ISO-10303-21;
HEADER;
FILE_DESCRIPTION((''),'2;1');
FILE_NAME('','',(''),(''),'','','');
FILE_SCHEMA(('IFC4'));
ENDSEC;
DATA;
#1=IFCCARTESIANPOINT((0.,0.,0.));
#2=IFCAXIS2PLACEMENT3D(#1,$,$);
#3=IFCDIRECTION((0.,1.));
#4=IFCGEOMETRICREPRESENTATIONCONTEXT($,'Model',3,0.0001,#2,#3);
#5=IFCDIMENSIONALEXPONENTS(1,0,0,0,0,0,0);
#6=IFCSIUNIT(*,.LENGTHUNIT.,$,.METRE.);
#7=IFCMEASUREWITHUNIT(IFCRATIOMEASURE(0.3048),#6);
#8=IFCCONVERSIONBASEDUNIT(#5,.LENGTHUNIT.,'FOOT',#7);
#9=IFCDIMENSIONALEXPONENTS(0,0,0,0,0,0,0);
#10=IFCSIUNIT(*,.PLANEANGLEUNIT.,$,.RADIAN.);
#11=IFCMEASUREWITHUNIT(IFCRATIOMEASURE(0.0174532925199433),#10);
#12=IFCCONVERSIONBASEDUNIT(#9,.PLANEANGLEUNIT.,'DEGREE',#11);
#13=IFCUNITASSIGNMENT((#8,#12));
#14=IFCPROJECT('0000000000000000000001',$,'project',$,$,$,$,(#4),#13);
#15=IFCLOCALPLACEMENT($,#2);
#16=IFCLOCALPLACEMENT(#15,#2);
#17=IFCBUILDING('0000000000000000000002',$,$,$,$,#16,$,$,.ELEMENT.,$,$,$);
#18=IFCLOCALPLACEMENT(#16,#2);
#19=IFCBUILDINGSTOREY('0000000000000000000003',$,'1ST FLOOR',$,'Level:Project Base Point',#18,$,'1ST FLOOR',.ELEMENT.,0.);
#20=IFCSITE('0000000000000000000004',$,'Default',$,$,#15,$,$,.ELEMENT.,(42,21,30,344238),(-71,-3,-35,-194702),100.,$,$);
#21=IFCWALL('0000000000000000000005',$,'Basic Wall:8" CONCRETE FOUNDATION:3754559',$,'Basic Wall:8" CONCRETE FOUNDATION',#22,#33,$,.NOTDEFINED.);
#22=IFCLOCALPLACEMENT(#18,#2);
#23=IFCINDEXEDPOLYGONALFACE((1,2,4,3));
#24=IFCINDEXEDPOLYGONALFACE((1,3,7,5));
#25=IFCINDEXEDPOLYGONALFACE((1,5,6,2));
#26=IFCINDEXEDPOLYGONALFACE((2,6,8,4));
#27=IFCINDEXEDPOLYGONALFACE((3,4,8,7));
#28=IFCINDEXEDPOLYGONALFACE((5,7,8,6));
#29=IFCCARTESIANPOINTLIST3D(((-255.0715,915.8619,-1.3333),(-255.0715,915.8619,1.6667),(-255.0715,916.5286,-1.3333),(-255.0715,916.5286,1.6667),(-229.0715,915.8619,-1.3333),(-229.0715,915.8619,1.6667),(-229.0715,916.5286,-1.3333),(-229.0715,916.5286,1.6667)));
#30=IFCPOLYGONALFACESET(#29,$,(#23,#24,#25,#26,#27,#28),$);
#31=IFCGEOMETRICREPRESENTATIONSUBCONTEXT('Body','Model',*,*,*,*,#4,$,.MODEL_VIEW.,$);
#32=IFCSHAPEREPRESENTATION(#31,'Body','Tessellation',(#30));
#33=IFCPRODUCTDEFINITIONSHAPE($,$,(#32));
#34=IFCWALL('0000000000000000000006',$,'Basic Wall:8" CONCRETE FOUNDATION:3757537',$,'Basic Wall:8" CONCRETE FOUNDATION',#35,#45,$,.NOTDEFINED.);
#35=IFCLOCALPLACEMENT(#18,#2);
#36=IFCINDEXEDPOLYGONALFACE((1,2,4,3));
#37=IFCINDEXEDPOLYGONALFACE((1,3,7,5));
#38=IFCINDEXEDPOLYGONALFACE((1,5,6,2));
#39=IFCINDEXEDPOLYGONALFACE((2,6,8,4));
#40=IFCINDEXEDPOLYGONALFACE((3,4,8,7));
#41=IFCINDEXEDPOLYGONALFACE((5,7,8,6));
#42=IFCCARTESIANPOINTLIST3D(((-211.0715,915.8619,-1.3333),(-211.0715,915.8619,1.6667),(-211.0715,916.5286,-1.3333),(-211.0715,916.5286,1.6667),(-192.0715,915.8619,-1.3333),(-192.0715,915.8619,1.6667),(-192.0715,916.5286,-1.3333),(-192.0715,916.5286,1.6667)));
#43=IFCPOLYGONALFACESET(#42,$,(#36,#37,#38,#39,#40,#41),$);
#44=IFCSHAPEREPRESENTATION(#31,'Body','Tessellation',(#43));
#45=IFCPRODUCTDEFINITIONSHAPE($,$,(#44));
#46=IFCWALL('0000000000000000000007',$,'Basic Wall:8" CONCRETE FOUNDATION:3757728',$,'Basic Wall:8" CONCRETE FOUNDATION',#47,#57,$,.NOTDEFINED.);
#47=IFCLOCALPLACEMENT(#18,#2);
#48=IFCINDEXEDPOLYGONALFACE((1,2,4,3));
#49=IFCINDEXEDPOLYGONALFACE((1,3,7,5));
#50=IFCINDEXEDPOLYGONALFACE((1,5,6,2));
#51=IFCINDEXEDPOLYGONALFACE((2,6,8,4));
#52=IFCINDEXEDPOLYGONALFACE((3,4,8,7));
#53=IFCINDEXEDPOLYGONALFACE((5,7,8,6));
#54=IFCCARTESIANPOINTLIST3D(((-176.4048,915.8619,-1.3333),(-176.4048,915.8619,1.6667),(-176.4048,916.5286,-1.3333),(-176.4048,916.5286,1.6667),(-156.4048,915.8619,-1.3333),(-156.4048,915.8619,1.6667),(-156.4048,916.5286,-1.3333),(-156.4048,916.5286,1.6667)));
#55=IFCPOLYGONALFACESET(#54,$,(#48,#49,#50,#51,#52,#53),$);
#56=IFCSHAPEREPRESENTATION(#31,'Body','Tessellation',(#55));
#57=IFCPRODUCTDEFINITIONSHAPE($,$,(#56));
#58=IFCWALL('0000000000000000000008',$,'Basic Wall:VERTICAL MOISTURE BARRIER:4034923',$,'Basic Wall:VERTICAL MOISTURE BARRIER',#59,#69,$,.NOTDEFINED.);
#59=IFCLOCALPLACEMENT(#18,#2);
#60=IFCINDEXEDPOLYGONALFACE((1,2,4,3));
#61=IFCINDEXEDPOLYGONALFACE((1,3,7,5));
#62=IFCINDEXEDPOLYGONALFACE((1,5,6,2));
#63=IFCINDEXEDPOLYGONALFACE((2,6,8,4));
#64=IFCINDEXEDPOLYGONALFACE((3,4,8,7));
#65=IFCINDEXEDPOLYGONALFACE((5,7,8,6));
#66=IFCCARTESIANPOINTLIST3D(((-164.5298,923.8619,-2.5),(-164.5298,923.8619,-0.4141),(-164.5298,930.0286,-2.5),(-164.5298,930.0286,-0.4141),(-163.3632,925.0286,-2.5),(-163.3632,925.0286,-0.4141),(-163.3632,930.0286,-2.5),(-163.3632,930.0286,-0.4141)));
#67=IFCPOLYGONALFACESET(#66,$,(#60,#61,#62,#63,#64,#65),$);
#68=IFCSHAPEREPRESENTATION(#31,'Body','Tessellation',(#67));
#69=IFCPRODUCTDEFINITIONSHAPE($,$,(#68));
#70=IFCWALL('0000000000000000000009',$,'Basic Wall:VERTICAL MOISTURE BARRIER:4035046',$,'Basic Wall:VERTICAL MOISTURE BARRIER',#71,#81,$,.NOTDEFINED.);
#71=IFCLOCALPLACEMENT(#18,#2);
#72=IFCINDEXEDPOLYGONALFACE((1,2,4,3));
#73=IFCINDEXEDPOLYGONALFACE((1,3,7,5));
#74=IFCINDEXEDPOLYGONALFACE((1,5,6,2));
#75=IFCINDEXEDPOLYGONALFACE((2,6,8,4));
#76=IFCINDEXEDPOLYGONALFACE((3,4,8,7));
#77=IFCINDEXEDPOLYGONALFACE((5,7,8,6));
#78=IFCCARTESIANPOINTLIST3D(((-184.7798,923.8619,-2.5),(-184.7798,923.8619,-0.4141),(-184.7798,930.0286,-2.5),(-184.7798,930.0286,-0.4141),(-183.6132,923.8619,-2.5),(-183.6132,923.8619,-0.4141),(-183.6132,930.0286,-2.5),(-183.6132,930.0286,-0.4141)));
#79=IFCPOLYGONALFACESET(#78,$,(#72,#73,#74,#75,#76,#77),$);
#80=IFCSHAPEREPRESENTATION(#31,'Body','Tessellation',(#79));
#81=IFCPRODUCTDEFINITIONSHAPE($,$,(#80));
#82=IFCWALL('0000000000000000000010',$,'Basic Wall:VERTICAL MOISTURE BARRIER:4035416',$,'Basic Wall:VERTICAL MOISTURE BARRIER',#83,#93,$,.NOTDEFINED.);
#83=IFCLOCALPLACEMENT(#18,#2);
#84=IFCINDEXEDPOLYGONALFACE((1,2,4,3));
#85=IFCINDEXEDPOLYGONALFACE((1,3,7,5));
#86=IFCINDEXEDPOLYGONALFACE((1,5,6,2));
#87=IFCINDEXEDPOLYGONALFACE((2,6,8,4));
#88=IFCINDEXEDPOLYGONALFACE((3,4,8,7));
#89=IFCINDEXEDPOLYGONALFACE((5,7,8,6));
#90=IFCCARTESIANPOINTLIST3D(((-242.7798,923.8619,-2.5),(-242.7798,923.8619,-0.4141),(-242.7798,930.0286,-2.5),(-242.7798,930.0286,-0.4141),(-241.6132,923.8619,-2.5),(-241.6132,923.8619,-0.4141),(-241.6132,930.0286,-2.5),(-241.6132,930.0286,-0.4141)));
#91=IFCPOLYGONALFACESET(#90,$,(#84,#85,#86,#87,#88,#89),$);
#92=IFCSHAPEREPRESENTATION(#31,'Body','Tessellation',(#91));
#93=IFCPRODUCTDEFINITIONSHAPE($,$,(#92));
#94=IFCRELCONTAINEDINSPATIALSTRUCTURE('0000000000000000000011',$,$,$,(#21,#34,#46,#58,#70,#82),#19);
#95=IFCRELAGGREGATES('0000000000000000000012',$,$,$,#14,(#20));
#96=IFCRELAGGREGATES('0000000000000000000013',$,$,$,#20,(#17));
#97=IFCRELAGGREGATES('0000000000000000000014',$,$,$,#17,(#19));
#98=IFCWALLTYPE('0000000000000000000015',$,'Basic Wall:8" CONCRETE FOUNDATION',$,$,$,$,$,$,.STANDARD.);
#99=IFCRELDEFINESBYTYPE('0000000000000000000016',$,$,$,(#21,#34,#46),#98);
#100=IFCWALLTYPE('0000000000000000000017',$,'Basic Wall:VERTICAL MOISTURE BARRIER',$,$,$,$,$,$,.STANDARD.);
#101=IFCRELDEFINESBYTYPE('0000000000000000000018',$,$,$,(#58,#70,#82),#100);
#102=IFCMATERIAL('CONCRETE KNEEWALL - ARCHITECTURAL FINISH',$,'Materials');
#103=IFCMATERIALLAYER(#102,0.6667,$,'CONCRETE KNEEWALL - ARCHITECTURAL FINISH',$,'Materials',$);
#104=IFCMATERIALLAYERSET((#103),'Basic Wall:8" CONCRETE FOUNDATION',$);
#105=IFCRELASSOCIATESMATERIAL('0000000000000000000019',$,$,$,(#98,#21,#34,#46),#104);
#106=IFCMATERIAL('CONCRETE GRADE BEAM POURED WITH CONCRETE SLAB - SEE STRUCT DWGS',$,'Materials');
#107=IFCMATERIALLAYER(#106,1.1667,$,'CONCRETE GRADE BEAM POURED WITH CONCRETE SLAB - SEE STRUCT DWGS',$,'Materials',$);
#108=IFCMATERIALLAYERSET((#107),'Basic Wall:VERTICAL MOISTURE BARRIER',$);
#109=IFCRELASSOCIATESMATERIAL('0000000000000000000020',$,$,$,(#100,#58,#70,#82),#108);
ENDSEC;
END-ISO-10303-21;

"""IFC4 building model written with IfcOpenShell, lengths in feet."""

from ifc_helpers import new_model, entity, si_unit, converted_unit, direction, frame, frame_2d, origin, place, context, subcontext, project, spatial, polyline, rectangle, outline, extrude, clip, bounded_halfspace, material, layer, layer_set, layer_usage, type_object, element, save


model = new_model("IFC4")

# Units and contexts
model_context = context("Model", 3, precision=0.0001, world=origin(), true_north=direction((0.0, 1.0)))
body_context = subcontext(model_context, "Body", "Model", "MODEL_VIEW")
ifc_project = project(units=[converted_unit("LENGTHUNIT", "FOOT", entity("IfcRatioMeasure", 0.3048), si_unit("LENGTHUNIT", "METRE"), dimensions=[1, 0, 0, 0, 0, 0, 0]), converted_unit("PLANEANGLEUNIT", "DEGREE", entity("IfcRatioMeasure", 0.0174532925199433), si_unit("PLANEANGLEUNIT", "RADIAN"), dimensions=[0, 0, 0, 0, 0, 0, 0])], contexts=[model_context])

# Site, building, storey
site_placement = place(None, origin())
site = spatial("IfcSite", under=ifc_project, at=site_placement, Name="Default", CompositionType="ELEMENT", RefLatitude=(42, 21, 30, 344238), RefLongitude=(-71, -3, -35, -194702), RefElevation=100.0)
building_placement = place(site_placement, origin())
building = spatial("IfcBuilding", under=site, at=building_placement, CompositionType="ELEMENT")
storey_placement = place(building_placement, origin())
storey = spatial("IfcBuildingStorey", under=building, at=storey_placement, Name="1ST FLOOR", ObjectType="Level:Project Base Point", LongName="1ST FLOOR", CompositionType="ELEMENT", Elevation=0.0)

# Walls
ifc_material_1 = material(Name="CONCRETE KNEEWALL - ARCHITECTURAL FINISH", Category="Materials")
ifc_layer_1 = layer(ifc_material_1, 0.6667, Name="CONCRETE KNEEWALL - ARCHITECTURAL FINISH", Category="Materials")
ifc_layer_set_1 = layer_set([ifc_layer_1], Name="Basic Wall:8\" CONCRETE FOUNDATION")
ifc_layer_usage_1 = layer_usage(ifc_layer_set_1, "AXIS2", "NEGATIVE", 0.3333)
wall_type_1 = type_object("IfcWallType", Name="Basic Wall:8\" CONCRETE FOUNDATION", PredefinedType="STANDARD", material=ifc_layer_set_1)
wall_1_placement = place(storey_placement, frame((-229.0715, 916.1953, -1.3333), z_axis=(0.0, 0.0, 1.0), x_axis=(-1.0, 0.0, 0.0)))
element("IfcWall", 1, at=wall_1_placement, inside=storey, type_object=wall_type_1, material=ifc_layer_usage_1, Name="Basic Wall:8\" CONCRETE FOUNDATION:3754559", ObjectType="Basic Wall:8\" CONCRETE FOUNDATION", PredefinedType="NOTDEFINED", context=body_context, shape_type="SweptSolid", body=[
    extrude(rectangle(XDim=26.0, YDim=0.6667, at=frame_2d((13.0, 0.0), x_axis=(-1.0, 0.0))), origin(), (0.0, 0.0, 1.0), 3.0),
])
ifc_layer_usage_2 = layer_usage(ifc_layer_set_1, "AXIS2", "NEGATIVE", 0.3333)
wall_2_placement = place(storey_placement, frame((-192.0715, 916.1953, -1.3333), z_axis=(0.0, 0.0, 1.0), x_axis=(-1.0, 0.0, 0.0)))
element("IfcWall", 2, at=wall_2_placement, inside=storey, type_object=wall_type_1, material=ifc_layer_usage_2, Name="Basic Wall:8\" CONCRETE FOUNDATION:3757537", ObjectType="Basic Wall:8\" CONCRETE FOUNDATION", PredefinedType="NOTDEFINED", context=body_context, shape_type="SweptSolid", body=[
    extrude(rectangle(XDim=19.0, YDim=0.6667, at=frame_2d((9.5, 0.0), x_axis=(-1.0, 0.0))), origin(), (0.0, 0.0, 1.0), 3.0),
])
ifc_layer_usage_3 = layer_usage(ifc_layer_set_1, "AXIS2", "NEGATIVE", 0.3333)
wall_3_placement = place(storey_placement, frame((-156.4048, 916.1953, -1.3333), z_axis=(0.0, 0.0, 1.0), x_axis=(-1.0, 0.0, 0.0)))
element("IfcWall", 3, at=wall_3_placement, inside=storey, type_object=wall_type_1, material=ifc_layer_usage_3, Name="Basic Wall:8\" CONCRETE FOUNDATION:3757728", ObjectType="Basic Wall:8\" CONCRETE FOUNDATION", PredefinedType="NOTDEFINED", context=body_context, shape_type="SweptSolid", body=[
    extrude(rectangle(XDim=20.0, YDim=0.6667, at=frame_2d((10.0, 0.0), x_axis=(-1.0, 0.0))), origin(), (0.0, 0.0, 1.0), 3.0),
])
ifc_material_2 = material(Name="CONCRETE GRADE BEAM POURED WITH CONCRETE SLAB - SEE STRUCT DWGS", Category="Materials")
ifc_layer_2 = layer(ifc_material_2, 1.1667, Name="CONCRETE GRADE BEAM POURED WITH CONCRETE SLAB - SEE STRUCT DWGS", Category="Materials")
ifc_layer_set_2 = layer_set([ifc_layer_2], Name="Basic Wall:VERTICAL MOISTURE BARRIER")
ifc_layer_usage_4 = layer_usage(ifc_layer_set_2, "AXIS2", "NEGATIVE", 0.5833)
wall_type_2 = type_object("IfcWallType", Name="Basic Wall:VERTICAL MOISTURE BARRIER", PredefinedType="STANDARD", material=ifc_layer_set_2)
wall_4_placement = place(storey_placement, frame((-163.9465, 923.8619, -2.5), z_axis=(0.0, 0.0, 1.0), x_axis=(0.0, 1.0, 0.0)))
element("IfcWall", 4, at=wall_4_placement, inside=storey, type_object=wall_type_2, material=ifc_layer_usage_4, Name="Basic Wall:VERTICAL MOISTURE BARRIER:4034923", ObjectType="Basic Wall:VERTICAL MOISTURE BARRIER", PredefinedType="NOTDEFINED", context=body_context, shape_type="Clipping", body=[
    clip(extrude(outline(polyline([(6.1667, -0.5833), (6.1667, 0.5833), (5.0, 0.5833), (0.0, 0.5833), (1.1667, -0.5833), (6.1667, -0.5833)])), origin(), (0.0, 0.0, 1.0), 2.0859), bounded_halfspace(frame((1.1667, -0.5833, 2.0859), z_axis=(0.0, 0.0, -1.0), x_axis=(0.0, -1.0, 0.0)), True, frame((1.1667, -0.5833, 2.0859)), polyline([(0.0, 0.0), (5.0, 0.0), (5.0, 1.1667), (3.8333, 1.1667), (-1.1667, 1.1667), (0.0, 0.0)]))),
])
ifc_layer_usage_5 = layer_usage(ifc_layer_set_2, "AXIS2", "POSITIVE", -0.5833)
wall_5_placement = place(storey_placement, frame((-184.1965, 923.8619, -2.5), z_axis=(0.0, 0.0, 1.0), x_axis=(0.0, 1.0, 0.0)))
element("IfcWall", 5, at=wall_5_placement, inside=storey, type_object=wall_type_2, material=ifc_layer_usage_5, Name="Basic Wall:VERTICAL MOISTURE BARRIER:4035046", ObjectType="Basic Wall:VERTICAL MOISTURE BARRIER", PredefinedType="NOTDEFINED", context=body_context, shape_type="Clipping", body=[
    clip(extrude(rectangle(XDim=6.1667, YDim=1.1667, at=frame_2d((3.0833, 0.0), x_axis=(-1.0, 0.0))), origin(), (0.0, 0.0, 1.0), 2.0859), bounded_halfspace(frame((0.0, -0.5833, 2.0859), z_axis=(0.0, 0.0, -1.0), x_axis=(0.0, -1.0, 0.0)), True, frame((0.0, -0.5833, 2.0859)), polyline([(0.0, 0.0), (5.0, 0.0), (6.1667, 0.0), (6.1667, 1.1667), (1.1667, 1.1667), (0.0, 1.1667), (0.0, 0.0)]))),
])
ifc_layer_usage_6 = layer_usage(ifc_layer_set_2, "AXIS2", "POSITIVE", -0.5833)
wall_6_placement = place(storey_placement, frame((-242.1965, 923.8619, -2.5), z_axis=(0.0, 0.0, 1.0), x_axis=(0.0, 1.0, 0.0)))
element("IfcWall", 6, at=wall_6_placement, inside=storey, type_object=wall_type_2, material=ifc_layer_usage_6, Name="Basic Wall:VERTICAL MOISTURE BARRIER:4035416", ObjectType="Basic Wall:VERTICAL MOISTURE BARRIER", PredefinedType="NOTDEFINED", context=body_context, shape_type="Clipping", body=[
    clip(extrude(rectangle(XDim=6.1667, YDim=1.1667, at=frame_2d((3.0833, 0.0), x_axis=(-1.0, 0.0))), origin(), (0.0, 0.0, 1.0), 2.0859), bounded_halfspace(frame((0.0, -0.5833, 2.0859), z_axis=(0.0, 0.0, -1.0), x_axis=(0.0, -1.0, 0.0)), True, frame((0.0, -0.5833, 2.0859)), polyline([(0.0, 0.0), (5.0, 0.0), (6.1667, 0.0), (6.1667, 1.1667), (1.1667, 1.1667), (0.0, 1.1667), (0.0, 0.0)]))),
])

save(model, "model.ifc")
